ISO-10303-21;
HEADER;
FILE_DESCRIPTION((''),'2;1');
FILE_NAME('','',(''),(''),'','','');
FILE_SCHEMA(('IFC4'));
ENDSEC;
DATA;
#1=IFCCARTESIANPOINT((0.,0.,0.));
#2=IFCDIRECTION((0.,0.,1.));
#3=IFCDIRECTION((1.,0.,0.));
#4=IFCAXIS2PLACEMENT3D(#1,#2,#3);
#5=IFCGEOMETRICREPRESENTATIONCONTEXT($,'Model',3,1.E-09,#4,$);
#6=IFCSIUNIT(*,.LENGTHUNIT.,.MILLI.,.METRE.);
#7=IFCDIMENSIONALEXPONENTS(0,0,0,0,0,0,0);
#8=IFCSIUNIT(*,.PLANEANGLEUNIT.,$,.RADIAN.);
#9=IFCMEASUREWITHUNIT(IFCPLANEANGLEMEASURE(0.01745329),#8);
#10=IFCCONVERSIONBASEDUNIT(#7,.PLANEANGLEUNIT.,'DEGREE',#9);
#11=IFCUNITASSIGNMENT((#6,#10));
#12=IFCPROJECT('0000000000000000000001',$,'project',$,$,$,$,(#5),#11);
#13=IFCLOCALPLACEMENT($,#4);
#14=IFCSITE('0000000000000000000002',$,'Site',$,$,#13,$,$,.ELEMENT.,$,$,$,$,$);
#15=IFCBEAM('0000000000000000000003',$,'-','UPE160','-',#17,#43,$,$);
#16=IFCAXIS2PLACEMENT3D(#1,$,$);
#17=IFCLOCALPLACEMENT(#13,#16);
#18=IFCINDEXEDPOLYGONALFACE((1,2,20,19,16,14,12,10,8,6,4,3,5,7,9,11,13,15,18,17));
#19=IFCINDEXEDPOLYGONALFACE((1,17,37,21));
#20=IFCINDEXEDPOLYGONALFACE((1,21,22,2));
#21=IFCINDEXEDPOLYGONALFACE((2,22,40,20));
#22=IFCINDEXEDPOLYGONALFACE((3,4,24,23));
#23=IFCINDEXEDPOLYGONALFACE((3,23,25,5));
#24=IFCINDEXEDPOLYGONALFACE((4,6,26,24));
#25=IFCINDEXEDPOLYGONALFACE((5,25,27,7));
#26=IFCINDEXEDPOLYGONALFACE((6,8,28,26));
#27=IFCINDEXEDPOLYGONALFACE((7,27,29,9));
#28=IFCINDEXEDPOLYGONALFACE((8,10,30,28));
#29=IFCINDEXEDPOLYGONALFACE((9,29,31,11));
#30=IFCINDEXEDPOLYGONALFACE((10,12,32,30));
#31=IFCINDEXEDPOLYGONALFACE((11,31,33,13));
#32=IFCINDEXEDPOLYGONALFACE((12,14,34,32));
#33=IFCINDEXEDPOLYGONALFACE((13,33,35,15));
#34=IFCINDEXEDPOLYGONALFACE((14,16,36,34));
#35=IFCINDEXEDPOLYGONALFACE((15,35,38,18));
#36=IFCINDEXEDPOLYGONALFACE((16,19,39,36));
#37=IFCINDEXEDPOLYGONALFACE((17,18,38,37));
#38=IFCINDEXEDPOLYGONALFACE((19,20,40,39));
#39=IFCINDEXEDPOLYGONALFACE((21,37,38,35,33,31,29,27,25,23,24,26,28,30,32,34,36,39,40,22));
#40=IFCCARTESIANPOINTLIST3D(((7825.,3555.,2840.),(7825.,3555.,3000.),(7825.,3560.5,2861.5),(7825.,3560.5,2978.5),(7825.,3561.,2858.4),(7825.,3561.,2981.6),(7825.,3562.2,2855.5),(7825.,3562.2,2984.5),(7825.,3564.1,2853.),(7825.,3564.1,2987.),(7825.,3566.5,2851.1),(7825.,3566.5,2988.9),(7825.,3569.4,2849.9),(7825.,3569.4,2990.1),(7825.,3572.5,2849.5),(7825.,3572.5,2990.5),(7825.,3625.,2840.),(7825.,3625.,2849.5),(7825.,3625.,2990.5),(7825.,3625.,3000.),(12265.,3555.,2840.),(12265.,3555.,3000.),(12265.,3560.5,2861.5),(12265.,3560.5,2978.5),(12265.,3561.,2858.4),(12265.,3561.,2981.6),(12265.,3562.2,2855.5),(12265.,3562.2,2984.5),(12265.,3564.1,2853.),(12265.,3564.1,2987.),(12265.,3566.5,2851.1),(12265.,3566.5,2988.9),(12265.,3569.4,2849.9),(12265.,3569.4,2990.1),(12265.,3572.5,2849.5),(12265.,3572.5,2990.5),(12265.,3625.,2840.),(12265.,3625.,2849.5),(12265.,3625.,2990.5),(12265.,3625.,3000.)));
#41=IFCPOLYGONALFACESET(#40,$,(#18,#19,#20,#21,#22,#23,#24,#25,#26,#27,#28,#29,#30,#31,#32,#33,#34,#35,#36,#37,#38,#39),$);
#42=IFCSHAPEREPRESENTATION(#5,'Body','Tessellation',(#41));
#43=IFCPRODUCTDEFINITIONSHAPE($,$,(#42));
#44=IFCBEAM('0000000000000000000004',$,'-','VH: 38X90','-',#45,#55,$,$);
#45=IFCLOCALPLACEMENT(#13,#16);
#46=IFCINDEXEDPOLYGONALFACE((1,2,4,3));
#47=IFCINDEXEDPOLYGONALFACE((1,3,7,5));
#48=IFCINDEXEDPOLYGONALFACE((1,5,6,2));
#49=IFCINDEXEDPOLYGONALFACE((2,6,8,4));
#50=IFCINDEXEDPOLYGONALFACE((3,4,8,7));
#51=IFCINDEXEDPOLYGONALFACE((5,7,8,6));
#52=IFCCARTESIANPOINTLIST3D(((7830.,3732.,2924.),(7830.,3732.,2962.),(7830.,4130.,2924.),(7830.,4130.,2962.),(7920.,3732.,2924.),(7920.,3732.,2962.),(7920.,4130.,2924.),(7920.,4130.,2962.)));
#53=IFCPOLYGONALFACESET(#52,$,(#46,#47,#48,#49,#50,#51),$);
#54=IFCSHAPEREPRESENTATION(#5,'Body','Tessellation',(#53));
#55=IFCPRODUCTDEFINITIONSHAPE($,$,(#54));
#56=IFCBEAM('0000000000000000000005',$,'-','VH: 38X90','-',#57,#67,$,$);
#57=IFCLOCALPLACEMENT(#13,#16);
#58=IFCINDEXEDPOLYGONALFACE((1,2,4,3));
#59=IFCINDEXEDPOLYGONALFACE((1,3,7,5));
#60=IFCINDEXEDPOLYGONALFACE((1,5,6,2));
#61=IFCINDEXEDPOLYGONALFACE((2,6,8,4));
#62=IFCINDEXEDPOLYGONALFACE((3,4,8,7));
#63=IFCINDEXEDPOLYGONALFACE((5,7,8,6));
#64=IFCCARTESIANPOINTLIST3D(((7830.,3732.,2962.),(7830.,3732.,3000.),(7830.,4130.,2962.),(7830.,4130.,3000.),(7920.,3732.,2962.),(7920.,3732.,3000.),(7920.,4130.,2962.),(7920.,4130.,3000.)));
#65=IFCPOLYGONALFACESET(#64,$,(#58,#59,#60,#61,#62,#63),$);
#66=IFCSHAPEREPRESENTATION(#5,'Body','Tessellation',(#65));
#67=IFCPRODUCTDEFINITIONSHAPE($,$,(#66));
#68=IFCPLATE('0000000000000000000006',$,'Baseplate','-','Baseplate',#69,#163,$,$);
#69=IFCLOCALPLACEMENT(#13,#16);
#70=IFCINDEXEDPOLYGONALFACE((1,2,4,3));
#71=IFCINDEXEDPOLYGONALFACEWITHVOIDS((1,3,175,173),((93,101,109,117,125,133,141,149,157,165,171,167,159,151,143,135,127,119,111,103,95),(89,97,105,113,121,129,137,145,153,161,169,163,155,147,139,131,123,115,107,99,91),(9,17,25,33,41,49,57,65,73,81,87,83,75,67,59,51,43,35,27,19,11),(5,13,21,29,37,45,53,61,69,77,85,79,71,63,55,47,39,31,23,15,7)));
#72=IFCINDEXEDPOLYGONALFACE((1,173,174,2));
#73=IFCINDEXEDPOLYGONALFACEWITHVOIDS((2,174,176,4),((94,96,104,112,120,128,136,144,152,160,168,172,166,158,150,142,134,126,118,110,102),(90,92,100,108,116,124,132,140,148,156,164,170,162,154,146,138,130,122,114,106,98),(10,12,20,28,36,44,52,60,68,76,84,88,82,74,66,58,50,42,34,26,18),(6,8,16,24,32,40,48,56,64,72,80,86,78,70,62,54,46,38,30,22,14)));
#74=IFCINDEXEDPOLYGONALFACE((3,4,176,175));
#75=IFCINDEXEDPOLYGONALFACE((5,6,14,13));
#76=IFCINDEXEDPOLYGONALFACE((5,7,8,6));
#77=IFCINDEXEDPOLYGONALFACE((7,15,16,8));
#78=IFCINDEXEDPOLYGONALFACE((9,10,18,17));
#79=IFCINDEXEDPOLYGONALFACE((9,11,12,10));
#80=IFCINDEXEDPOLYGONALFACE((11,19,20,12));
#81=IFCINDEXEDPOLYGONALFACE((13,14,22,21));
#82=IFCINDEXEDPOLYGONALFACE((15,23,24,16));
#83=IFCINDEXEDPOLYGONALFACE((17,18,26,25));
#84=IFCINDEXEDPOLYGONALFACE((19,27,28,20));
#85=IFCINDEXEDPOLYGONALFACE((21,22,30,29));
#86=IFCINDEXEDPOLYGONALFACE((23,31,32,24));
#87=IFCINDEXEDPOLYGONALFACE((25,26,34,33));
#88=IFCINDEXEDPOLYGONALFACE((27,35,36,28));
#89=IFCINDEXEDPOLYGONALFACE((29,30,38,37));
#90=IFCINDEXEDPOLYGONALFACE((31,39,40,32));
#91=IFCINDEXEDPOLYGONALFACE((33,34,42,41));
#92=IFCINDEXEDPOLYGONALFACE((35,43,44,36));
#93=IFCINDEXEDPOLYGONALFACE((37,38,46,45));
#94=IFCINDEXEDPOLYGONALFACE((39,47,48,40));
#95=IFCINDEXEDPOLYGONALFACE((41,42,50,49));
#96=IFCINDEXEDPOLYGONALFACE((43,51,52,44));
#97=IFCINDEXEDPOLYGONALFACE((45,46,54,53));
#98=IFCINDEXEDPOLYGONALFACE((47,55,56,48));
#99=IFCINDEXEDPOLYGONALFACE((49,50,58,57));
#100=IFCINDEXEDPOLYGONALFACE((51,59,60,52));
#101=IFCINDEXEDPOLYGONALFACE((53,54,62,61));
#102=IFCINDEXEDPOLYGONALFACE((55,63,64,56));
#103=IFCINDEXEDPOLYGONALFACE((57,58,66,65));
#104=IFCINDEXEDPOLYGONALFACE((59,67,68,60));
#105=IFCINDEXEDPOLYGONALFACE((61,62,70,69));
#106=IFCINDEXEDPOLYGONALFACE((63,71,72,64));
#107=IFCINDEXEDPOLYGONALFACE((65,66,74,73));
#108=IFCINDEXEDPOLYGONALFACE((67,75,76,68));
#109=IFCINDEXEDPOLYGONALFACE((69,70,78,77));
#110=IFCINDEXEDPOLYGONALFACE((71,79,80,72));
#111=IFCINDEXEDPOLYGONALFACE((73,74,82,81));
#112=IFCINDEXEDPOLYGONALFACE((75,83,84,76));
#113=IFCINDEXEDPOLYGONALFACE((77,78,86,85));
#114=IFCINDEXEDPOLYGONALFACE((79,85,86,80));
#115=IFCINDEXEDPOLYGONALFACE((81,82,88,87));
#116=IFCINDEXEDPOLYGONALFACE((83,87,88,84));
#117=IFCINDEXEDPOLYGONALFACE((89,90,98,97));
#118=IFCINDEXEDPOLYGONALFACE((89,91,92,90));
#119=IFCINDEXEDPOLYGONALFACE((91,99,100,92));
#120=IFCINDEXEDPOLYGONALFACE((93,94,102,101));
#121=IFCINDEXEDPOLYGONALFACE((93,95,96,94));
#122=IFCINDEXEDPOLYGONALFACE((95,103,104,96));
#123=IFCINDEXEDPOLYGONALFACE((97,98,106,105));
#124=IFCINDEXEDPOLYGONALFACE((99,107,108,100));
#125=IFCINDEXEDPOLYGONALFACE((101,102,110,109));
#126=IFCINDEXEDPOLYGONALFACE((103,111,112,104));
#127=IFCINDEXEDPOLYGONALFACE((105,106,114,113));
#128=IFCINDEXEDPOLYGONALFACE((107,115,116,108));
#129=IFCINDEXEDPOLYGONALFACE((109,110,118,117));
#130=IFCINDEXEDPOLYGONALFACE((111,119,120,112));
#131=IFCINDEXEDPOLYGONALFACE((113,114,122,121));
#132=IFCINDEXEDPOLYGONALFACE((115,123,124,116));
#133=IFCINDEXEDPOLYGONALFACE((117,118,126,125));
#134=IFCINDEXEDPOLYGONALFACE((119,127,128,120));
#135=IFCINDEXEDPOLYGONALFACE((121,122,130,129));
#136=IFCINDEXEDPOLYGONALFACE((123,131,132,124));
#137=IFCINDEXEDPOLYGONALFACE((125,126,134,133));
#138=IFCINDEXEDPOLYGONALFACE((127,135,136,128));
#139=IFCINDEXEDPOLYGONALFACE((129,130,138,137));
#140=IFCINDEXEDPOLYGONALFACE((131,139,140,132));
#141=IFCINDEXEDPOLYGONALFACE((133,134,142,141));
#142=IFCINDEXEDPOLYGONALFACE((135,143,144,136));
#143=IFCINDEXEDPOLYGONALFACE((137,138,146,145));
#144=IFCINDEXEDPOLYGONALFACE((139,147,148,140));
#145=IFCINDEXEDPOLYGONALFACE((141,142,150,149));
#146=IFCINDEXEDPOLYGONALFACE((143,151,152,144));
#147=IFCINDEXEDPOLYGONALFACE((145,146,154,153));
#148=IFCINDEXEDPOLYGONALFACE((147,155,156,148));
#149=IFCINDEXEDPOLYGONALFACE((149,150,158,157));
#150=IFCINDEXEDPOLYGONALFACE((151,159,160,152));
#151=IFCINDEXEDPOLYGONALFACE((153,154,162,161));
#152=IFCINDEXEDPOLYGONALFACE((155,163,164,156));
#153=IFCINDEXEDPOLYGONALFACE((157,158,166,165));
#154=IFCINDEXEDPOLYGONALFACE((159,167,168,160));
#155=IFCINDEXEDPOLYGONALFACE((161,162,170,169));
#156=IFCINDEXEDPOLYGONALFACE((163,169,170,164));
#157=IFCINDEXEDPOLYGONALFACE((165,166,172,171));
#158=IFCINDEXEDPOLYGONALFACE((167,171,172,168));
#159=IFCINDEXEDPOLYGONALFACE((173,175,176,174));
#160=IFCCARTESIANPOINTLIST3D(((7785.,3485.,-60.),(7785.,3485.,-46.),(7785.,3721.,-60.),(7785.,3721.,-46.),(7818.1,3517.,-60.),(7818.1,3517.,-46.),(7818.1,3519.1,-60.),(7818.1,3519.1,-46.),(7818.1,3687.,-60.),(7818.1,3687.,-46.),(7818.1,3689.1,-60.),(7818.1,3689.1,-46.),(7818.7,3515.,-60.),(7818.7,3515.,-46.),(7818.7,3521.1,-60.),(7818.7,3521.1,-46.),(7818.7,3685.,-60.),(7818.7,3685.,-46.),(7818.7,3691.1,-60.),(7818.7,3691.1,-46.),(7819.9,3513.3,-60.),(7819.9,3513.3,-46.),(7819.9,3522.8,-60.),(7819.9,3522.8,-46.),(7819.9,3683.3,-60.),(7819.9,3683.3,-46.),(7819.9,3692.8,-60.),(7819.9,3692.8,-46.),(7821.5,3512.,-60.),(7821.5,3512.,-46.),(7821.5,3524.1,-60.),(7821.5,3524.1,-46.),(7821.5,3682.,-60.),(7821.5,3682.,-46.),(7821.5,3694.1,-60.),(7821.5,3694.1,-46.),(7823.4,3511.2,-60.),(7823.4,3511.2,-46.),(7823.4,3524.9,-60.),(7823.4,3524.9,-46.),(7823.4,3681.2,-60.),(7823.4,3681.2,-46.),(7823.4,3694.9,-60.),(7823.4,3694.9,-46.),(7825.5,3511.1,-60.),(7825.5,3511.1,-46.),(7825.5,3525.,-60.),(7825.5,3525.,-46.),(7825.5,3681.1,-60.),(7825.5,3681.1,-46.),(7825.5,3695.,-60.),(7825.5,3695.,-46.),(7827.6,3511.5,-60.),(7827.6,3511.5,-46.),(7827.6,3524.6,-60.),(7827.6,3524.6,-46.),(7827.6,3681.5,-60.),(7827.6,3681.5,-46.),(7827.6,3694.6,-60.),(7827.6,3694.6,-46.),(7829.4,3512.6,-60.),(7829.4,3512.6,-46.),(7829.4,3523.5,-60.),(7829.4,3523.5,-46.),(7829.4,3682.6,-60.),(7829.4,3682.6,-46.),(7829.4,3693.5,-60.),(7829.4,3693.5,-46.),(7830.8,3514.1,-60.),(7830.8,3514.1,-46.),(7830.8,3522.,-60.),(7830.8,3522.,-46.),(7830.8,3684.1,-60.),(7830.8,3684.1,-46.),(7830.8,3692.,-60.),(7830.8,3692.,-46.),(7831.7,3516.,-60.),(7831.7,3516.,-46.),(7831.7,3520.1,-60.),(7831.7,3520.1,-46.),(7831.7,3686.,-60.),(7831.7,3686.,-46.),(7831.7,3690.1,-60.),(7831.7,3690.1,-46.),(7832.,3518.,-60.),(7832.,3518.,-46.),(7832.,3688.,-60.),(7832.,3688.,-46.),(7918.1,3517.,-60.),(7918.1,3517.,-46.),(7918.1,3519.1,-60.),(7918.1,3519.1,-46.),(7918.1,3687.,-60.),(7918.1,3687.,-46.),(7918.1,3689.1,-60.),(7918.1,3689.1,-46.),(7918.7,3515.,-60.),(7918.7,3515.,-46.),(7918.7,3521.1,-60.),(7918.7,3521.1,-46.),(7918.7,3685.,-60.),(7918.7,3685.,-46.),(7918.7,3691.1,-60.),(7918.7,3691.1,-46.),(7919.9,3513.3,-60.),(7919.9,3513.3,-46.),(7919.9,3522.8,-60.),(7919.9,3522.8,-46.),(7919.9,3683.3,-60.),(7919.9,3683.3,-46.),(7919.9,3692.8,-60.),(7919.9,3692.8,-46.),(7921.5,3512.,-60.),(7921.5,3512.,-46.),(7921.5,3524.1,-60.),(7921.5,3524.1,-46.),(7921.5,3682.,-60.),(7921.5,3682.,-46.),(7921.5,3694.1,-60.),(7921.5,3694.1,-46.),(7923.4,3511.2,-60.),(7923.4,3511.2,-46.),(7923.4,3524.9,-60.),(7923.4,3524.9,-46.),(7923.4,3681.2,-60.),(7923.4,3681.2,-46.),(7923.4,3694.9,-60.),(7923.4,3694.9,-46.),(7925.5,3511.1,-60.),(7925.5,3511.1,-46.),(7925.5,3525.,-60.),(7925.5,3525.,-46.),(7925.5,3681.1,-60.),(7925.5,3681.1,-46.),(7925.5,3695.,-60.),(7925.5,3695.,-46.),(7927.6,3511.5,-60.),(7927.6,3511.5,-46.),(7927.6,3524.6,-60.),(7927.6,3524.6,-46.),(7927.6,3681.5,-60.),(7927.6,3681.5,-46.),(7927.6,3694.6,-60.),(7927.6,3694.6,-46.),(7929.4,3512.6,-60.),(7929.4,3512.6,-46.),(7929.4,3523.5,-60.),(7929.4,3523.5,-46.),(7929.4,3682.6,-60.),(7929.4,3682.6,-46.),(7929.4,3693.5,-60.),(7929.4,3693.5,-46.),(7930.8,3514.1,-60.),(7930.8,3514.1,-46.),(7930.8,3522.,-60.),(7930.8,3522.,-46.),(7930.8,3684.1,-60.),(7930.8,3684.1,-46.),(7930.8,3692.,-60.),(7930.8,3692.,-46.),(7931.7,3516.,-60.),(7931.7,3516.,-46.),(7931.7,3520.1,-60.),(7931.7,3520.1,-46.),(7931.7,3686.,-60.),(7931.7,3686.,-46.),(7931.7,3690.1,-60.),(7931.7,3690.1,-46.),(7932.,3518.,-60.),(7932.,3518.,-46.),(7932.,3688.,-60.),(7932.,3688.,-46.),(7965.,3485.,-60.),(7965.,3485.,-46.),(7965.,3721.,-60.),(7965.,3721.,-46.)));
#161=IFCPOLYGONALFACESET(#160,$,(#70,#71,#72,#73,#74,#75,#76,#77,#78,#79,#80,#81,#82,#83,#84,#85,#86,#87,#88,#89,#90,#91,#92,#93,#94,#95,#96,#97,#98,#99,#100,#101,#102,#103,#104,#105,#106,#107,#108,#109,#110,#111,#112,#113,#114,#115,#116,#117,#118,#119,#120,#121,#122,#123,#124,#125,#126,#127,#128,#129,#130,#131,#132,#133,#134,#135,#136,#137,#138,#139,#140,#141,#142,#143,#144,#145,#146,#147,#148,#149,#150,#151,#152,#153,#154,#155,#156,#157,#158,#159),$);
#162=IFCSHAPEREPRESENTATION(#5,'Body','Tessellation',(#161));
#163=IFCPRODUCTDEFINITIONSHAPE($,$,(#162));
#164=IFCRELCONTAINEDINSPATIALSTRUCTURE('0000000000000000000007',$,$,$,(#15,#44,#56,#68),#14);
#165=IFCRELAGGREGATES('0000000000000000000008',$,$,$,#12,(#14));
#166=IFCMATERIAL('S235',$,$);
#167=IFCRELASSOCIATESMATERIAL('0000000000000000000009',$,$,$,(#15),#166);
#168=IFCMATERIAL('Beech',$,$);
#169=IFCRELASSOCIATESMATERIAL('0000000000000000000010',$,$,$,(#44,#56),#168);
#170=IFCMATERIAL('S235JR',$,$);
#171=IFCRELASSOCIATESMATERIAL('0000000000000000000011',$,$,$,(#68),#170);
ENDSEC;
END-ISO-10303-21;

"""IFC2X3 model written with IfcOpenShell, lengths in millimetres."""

from ifc_helpers import new_model, entity, si_unit, converted_unit, frame, frame_2d, origin, origin_with_axes, origin_2d, place, context, project, spatial, polyline, rectangle, circle, u_section, outline, extrude, material, element, save


model = new_model("IFC2X3")

# Units and contexts
model_context = context("Model", 3, precision=1e-09, world=origin_with_axes())
ifc_project = project(units=[si_unit("LENGTHUNIT", "METRE", prefix="MILLI"), converted_unit("PLANEANGLEUNIT", "DEGREE", entity("IfcPlaneAngleMeasure", 0.01745329), si_unit("PLANEANGLEUNIT", "RADIAN"), dimensions=[0, 0, 0, 0, 0, 0, 0])], contexts=[model_context])

# Site
site_placement = place(None, origin_with_axes())
site = spatial("IfcSite", under=ifc_project, at=site_placement, Name="Site", CompositionType="ELEMENT")

# Shared definitions
ifc_material_1 = material(Name="Beech")
ifc_material_2 = material(Name="S235")

# Beams
beam_1_placement = place(None, frame((7825.0, 3577.7, 2920.0), z_axis=(1.0, 0.0, 0.0), x_axis=(0.0, 1.0, 0.0)))
element("IfcBeam", 1, at=beam_1_placement, inside=site, material=ifc_material_2, Name="-", Description="UPE160", ObjectType="-", context=model_context, shape_type="SweptSolid", body=[
    extrude(u_section(Depth=160.0, FlangeWidth=70.0, WebThickness=5.5, FlangeThickness=9.5, FilletRadius=12.0, EdgeRadius=0.0, FlangeSlope=0.0, at=frame_2d((12.3, 0.0))), origin(), (0.0, 0.0, 1.0), 4440.0),
])
for number, where, z_axis, x_axis, name in (
    (2, (7875.0, 3732.0, 2943.0), (0.0, -1.0, 0.0), (0.0, 0.0, -1.0), "-"),
    (3, (7875.0, 3732.0, 2981.0), (0.0, -1.0, 0.0), (0.0, 0.0, -1.0), "-"),
):
    element("IfcBeam", number, at=place(None, frame(where, z_axis=z_axis, x_axis=x_axis)), inside=site, material=ifc_material_1, Name=name, Description="VH: 38X90", ObjectType="-", context=model_context, shape_type="SweptSolid", body=[
        extrude(rectangle(XDim=38.0, YDim=90.0, at=origin_2d()), origin(), (0.0, 0.0, -1.0), 398.0),
    ])

# Plate, openings
ifc_material_3 = material(Name="S235JR")
plate_placement = place(None, frame((7785.0, 3721.0, -46.0), z_axis=(0.0, 0.0, -1.0), x_axis=(1.0, 0.0, 0.0)))
plate = element("IfcPlate", 4, at=plate_placement, inside=site, material=ifc_material_3, Name="Baseplate", Description="-", ObjectType="Baseplate", context=model_context, shape_type="SweptSolid", body=[
    extrude(outline(polyline([(0.0, 0.0), (180.0, 0.0), (180.0, 236.0), (0.0, 236.0), (0.0, 0.0)])), origin_with_axes(), (0.0, 0.0, 1.0), 14.0),
])
opening_1_placement = place(plate_placement, frame((90.0, 118.0, 14.5), z_axis=(0.0, 0.0, -1.0), x_axis=(1.0, 0.0, 0.0)))
element("IfcOpeningElement", 5, at=opening_1_placement, cuts=plate, ObjectType="Opening", context=model_context, shape_type="SweptSolid", body=[
    extrude(circle(Radius=7.0, at=frame_2d((50.0, 85.0), x_axis=(1.0, 0.0))), origin(), (0.0, 0.0, 1.0), 15.0),
])
opening_2_placement = place(plate_placement, frame((90.0, 118.0, 14.5), z_axis=(0.0, 0.0, -1.0), x_axis=(1.0, 0.0, 0.0)))
element("IfcOpeningElement", 6, at=opening_2_placement, cuts=plate, ObjectType="Opening", context=model_context, shape_type="SweptSolid", body=[
    extrude(circle(Radius=7.0, at=frame_2d((-50.0, 85.0), x_axis=(1.0, 0.0))), origin(), (0.0, 0.0, 1.0), 15.0),
])
opening_3_placement = place(plate_placement, frame((90.0, 118.0, 14.5), z_axis=(0.0, 0.0, -1.0), x_axis=(1.0, 0.0, 0.0)))
element("IfcOpeningElement", 7, at=opening_3_placement, cuts=plate, ObjectType="Opening", context=model_context, shape_type="SweptSolid", body=[
    extrude(circle(Radius=7.0, at=frame_2d((50.0, -85.0), x_axis=(1.0, 0.0))), origin(), (0.0, 0.0, 1.0), 15.0),
])
opening_4_placement = place(plate_placement, frame((90.0, 118.0, 14.5), z_axis=(0.0, 0.0, -1.0), x_axis=(1.0, 0.0, 0.0)))
element("IfcOpeningElement", 8, at=opening_4_placement, cuts=plate, ObjectType="Opening", context=model_context, shape_type="SweptSolid", body=[
    extrude(circle(Radius=7.0, at=frame_2d((-50.0, -85.0), x_axis=(1.0, 0.0))), origin(), (0.0, 0.0, 1.0), 15.0),
])

save(model, "model.ifc")
